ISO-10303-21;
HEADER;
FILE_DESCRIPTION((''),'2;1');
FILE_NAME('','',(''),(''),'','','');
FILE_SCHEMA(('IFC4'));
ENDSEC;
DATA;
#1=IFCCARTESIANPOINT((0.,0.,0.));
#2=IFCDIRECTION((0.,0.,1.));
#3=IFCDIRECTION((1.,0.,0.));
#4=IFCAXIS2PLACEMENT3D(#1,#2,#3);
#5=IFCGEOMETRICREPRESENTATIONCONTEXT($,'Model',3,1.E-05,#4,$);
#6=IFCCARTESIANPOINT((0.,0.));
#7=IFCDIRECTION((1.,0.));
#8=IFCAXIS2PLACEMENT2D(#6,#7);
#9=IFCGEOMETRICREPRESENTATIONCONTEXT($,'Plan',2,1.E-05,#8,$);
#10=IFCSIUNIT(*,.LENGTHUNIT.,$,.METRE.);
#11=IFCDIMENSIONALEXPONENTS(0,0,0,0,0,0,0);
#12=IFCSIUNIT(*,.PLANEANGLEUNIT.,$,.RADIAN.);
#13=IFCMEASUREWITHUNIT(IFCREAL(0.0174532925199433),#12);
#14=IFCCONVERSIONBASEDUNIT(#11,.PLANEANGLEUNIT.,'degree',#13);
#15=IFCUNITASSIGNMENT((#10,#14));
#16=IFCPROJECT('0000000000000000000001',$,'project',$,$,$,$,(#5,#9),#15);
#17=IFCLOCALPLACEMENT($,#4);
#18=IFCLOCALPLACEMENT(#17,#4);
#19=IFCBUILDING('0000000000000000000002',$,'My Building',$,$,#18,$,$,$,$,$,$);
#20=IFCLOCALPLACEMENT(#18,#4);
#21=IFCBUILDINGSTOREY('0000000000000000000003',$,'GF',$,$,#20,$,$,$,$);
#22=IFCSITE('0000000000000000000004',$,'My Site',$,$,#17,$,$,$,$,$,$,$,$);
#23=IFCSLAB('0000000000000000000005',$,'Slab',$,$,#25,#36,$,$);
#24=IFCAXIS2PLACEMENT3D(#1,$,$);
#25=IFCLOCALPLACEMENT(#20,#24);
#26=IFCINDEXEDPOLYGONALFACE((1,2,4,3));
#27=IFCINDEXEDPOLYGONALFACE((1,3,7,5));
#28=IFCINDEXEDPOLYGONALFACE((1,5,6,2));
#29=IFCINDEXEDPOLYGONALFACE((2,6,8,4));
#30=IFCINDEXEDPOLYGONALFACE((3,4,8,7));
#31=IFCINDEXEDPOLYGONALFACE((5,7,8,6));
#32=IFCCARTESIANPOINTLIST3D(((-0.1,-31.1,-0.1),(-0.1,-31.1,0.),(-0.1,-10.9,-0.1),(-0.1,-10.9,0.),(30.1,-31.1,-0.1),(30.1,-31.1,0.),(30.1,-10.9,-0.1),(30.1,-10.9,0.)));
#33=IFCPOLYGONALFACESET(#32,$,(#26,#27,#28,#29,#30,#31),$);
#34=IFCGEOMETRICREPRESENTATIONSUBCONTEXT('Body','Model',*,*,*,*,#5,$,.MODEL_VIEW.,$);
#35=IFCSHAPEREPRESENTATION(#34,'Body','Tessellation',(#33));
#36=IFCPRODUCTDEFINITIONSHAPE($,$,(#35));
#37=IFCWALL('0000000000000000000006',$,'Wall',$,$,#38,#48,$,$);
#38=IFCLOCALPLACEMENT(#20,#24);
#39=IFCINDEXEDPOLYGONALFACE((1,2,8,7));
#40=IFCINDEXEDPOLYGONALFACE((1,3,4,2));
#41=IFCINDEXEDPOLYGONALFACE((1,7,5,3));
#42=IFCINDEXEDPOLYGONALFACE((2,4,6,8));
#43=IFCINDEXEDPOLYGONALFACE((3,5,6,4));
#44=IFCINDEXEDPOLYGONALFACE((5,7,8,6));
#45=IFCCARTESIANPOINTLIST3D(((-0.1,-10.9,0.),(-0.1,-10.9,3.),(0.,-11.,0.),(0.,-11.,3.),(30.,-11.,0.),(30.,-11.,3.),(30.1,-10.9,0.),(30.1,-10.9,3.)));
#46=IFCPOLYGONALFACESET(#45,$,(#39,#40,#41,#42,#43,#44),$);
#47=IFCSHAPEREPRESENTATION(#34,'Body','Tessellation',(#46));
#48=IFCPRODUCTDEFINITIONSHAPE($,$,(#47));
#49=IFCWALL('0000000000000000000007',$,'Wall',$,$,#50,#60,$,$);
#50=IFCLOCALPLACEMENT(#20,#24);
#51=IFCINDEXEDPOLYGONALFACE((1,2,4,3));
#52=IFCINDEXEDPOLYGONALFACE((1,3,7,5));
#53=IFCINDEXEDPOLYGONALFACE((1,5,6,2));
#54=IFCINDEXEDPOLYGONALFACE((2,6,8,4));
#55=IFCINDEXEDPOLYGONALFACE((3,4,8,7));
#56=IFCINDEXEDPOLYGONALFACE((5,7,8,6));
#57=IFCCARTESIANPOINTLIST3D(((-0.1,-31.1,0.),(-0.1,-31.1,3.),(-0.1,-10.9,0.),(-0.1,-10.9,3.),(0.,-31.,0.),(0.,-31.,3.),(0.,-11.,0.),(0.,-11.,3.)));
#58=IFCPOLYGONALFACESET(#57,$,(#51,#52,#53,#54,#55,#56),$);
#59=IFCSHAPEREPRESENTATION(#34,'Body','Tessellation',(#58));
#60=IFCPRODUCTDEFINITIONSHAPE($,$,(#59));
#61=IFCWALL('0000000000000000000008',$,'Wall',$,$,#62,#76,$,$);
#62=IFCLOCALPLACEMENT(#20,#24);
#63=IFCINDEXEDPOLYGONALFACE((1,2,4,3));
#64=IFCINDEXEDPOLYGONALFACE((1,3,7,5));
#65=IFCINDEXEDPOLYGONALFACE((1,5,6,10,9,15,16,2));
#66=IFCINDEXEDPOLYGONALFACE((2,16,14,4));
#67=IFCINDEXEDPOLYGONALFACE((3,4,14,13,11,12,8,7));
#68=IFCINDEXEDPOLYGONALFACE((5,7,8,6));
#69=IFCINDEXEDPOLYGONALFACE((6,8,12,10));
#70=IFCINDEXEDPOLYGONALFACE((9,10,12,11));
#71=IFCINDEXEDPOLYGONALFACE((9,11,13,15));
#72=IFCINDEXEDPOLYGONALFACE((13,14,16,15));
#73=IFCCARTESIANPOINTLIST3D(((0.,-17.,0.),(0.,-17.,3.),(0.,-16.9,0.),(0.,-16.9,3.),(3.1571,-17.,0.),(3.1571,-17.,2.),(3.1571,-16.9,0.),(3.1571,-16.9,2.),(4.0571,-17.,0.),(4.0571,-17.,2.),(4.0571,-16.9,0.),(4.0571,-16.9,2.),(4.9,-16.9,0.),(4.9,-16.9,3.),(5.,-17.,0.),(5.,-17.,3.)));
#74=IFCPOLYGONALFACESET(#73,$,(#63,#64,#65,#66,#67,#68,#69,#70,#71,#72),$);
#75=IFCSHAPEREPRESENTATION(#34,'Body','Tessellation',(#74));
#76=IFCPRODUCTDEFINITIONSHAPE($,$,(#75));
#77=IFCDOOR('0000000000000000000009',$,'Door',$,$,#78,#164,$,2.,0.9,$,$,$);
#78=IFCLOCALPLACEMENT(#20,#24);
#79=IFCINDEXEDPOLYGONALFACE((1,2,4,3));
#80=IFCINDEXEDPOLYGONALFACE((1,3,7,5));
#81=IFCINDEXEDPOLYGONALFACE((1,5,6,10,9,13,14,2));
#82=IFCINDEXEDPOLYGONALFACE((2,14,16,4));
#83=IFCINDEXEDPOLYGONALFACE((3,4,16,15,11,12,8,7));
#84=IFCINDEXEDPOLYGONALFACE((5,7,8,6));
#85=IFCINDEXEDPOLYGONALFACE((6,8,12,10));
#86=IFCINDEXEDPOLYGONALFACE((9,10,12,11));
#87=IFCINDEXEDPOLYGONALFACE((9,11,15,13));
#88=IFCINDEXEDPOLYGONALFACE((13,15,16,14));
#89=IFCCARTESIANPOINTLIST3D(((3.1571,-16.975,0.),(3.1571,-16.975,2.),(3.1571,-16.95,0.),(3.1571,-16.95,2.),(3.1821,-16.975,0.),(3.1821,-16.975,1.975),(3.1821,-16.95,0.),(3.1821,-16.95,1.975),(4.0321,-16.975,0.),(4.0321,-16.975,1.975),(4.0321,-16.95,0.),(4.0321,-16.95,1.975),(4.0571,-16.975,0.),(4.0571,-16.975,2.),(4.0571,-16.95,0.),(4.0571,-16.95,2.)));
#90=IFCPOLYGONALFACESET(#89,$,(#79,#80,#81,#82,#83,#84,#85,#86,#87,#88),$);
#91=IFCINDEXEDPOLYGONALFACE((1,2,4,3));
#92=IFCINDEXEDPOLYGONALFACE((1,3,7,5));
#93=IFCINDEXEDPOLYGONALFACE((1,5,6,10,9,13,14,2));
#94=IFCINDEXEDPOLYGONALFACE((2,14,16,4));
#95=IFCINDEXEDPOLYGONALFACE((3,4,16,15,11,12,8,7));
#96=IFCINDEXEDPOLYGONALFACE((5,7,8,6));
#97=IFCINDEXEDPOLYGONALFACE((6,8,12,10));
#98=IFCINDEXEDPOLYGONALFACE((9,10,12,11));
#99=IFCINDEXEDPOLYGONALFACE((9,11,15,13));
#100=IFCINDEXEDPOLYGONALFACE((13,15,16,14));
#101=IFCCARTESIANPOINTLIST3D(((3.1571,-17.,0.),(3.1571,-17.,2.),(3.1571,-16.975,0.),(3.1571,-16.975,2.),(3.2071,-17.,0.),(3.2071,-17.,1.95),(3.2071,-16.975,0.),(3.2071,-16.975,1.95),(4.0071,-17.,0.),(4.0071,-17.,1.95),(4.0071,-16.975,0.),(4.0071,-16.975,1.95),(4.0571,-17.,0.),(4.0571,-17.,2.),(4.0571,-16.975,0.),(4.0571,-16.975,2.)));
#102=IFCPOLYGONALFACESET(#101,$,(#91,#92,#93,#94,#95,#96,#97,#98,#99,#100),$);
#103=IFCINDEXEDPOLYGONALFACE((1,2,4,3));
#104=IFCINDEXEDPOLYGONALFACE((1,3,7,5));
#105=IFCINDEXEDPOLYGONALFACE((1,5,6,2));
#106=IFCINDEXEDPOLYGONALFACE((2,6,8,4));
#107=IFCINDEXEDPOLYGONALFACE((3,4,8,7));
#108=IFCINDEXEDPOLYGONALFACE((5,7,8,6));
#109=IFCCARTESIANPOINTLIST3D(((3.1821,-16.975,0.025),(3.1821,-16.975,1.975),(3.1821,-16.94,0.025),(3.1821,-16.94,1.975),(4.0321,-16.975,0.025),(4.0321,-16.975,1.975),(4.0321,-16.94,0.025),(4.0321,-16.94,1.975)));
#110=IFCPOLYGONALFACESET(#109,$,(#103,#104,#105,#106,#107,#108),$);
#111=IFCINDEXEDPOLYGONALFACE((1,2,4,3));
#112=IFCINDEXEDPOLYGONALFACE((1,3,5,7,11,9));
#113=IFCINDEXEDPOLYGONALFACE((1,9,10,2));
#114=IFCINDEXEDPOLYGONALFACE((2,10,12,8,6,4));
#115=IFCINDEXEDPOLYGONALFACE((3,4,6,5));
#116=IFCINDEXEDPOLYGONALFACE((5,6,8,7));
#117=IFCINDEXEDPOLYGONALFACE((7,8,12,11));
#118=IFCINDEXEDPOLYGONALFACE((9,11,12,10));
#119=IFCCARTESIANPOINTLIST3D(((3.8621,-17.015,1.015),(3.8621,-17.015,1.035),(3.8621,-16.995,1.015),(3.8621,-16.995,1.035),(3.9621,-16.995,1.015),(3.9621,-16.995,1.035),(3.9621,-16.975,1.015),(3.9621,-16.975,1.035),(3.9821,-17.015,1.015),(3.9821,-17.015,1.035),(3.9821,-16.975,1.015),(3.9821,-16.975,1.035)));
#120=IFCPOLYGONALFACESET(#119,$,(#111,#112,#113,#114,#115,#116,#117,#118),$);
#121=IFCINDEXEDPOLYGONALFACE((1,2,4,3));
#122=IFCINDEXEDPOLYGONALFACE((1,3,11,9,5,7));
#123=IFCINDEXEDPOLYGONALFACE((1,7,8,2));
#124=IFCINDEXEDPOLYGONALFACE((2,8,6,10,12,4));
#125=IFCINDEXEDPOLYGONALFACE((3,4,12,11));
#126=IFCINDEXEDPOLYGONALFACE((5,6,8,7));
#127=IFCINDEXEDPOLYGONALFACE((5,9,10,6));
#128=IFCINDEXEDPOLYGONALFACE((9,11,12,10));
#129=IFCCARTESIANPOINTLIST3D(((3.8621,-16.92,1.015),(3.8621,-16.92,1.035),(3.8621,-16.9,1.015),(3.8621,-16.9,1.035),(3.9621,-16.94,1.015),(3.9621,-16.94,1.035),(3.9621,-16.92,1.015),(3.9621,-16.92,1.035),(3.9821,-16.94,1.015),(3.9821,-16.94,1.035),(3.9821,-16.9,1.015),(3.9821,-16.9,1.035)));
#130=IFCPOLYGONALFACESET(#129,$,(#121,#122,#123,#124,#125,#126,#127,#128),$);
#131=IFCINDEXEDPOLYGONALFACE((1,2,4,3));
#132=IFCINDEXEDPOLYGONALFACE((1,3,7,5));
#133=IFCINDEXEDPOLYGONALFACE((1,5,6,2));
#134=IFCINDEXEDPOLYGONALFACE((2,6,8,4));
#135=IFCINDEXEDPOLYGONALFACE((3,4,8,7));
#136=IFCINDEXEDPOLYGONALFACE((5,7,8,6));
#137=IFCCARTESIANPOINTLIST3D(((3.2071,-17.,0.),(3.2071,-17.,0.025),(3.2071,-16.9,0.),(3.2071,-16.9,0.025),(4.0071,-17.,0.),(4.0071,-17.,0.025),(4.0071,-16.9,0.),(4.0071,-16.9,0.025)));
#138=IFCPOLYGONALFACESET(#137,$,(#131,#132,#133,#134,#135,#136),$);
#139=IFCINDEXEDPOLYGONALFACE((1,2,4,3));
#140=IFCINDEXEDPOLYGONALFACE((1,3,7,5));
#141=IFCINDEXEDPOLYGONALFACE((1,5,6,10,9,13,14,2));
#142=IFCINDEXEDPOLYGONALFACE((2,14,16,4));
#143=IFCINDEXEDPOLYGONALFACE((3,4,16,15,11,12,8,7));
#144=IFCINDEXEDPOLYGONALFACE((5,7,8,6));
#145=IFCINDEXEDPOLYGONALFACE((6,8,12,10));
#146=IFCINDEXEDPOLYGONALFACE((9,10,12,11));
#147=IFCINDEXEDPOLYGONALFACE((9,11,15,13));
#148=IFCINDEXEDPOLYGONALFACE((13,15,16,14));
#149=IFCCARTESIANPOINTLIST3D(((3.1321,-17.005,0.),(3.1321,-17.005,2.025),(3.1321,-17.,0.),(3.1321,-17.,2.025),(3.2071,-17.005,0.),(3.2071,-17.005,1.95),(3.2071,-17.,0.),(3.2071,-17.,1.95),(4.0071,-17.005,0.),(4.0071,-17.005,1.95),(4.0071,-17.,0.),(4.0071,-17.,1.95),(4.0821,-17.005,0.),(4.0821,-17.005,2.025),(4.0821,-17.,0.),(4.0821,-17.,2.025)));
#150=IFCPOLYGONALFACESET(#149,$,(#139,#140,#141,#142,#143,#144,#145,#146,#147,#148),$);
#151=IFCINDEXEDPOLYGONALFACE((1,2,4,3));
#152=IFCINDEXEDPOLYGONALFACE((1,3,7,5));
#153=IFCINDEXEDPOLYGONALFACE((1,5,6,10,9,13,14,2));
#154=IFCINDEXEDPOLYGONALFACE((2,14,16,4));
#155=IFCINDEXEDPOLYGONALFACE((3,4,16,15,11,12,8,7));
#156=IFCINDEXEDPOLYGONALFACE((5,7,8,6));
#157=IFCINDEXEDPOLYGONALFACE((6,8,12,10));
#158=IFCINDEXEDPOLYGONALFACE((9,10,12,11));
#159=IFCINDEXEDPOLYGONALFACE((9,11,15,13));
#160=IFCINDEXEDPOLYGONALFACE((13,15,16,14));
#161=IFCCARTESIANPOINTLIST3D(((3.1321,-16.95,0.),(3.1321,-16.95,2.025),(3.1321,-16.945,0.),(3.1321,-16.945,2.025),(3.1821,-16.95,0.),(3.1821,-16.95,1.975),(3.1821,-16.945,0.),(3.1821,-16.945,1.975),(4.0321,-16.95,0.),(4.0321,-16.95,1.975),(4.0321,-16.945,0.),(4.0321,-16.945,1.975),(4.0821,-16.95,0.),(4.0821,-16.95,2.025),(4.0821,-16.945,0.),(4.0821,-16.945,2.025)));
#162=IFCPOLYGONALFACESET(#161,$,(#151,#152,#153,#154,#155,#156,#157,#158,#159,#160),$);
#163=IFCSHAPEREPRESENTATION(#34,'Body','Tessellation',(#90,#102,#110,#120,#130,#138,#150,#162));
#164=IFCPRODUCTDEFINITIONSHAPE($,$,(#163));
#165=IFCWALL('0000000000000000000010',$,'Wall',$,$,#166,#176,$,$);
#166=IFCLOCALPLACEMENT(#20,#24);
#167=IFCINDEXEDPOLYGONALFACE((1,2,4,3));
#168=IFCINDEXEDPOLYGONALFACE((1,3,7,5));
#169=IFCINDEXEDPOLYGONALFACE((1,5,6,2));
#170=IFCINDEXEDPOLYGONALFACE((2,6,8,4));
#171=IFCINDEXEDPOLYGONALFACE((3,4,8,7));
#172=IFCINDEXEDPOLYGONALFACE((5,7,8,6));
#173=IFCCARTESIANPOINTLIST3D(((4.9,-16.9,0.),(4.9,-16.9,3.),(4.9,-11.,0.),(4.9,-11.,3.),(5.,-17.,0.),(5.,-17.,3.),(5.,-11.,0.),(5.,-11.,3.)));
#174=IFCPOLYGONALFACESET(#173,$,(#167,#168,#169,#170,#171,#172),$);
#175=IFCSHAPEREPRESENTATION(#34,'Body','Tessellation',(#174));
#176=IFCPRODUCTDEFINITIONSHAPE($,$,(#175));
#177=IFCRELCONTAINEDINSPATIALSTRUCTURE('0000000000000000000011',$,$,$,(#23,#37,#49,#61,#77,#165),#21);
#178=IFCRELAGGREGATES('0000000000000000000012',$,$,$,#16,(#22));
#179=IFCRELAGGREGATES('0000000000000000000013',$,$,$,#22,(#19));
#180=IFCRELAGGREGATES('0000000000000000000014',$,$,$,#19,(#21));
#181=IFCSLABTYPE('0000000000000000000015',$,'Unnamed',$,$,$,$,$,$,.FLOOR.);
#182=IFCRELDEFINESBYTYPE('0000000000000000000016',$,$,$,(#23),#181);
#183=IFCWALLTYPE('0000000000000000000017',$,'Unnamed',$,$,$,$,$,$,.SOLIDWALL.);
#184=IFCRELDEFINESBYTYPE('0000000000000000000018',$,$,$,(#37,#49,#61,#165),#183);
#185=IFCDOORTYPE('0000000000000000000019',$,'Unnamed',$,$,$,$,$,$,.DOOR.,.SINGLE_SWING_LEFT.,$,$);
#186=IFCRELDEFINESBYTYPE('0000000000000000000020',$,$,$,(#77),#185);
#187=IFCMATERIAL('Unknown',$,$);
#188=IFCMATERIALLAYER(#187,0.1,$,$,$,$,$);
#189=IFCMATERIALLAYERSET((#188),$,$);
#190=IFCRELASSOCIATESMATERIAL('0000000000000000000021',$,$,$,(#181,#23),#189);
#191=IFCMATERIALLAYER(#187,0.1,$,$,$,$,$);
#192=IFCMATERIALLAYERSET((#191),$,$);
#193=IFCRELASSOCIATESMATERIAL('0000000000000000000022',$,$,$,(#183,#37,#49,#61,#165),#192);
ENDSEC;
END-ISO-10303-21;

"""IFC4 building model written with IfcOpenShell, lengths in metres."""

from ifc_helpers import new_model, entity, si_unit, converted_unit, frame, origin_with_axes, origin_2d_with_axis, place, context, subcontext, project, spatial, line, indexed_curve, outline, extrude, shape, source, transform, mapped, material, layer, layer_set, layer_usage, type_object, type_shapes, element, fill, save


model = new_model("IFC4")

# Units and contexts
model_context = context("Model", 3, precision=1e-05, world=origin_with_axes())
plan_context = context("Plan", 2, precision=1e-05, world=origin_2d_with_axis())
body_context_1 = subcontext(model_context, "Body", "Model", "MODEL_VIEW")
body_context_2 = subcontext(plan_context, "Body", "Plan", "PLAN_VIEW")
ifc_project = project(units=[si_unit("LENGTHUNIT", "METRE"), converted_unit("PLANEANGLEUNIT", "degree", entity("IfcReal", 0.0174532925199433), si_unit("PLANEANGLEUNIT", "RADIAN"), dimensions=[0, 0, 0, 0, 0, 0, 0])], contexts=[model_context, plan_context])

# Site, building, storey
site_placement = place(None, origin_with_axes())
site = spatial("IfcSite", under=ifc_project, at=site_placement, Name="My Site")
building_placement = place(site_placement, origin_with_axes())
building = spatial("IfcBuilding", under=site, at=building_placement, Name="My Building")
storey_placement = place(building_placement, origin_with_axes())
storey = spatial("IfcBuildingStorey", under=building, at=storey_placement, Name="GF")

# Slab
ifc_material = material(Name="Unknown")
ifc_layer_1 = layer(ifc_material, 0.1)
ifc_layer_set_1 = layer_set([ifc_layer_1])
ifc_layer_usage_1 = layer_usage(ifc_layer_set_1, "AXIS3", "POSITIVE", -0.1)
slab_type = type_object("IfcSlabType", Name="Unnamed", PredefinedType="FLOOR", material=ifc_layer_set_1)
slab_placement = place(storey_placement, frame((-0.1, -10.9, 0.0), z_axis=(0.0, 0.0, 1.0), x_axis=(1.0, 0.0, 0.0)))
element("IfcSlab", 1, at=slab_placement, inside=storey, type_object=slab_type, material=ifc_layer_usage_1, Name="Slab", context=body_context_1, shape_type="SweptSolid", body=[
    extrude(outline(indexed_curve([(0.0, 0.0), (30.2, 0.0), (30.2, -20.2), (0.0, -20.2), (0.0, 0.0)])), frame((0.0, 0.0, -0.1), z_axis=(0.0, 0.0, 1.0), x_axis=(1.0, 0.0, 0.0)), (0.0, 0.0, 1.0), 0.1),
])

# Walls
ifc_layer_2 = layer(ifc_material, 0.1)
ifc_layer_set_2 = layer_set([ifc_layer_2])
ifc_layer_usage_2 = layer_usage(ifc_layer_set_2, "AXIS2", "POSITIVE", 0.0)
wall_type = type_object("IfcWallType", Name="Unnamed", PredefinedType="SOLIDWALL", material=ifc_layer_set_2)
wall_1_placement = place(storey_placement, frame((0.0, -11.0, 0.0), z_axis=(0.0, 0.0, 1.0), x_axis=(1.0, 0.0, 0.0)))
element("IfcWall", 2, at=wall_1_placement, inside=storey, type_object=wall_type, material=ifc_layer_usage_2, Name="Wall", context=body_context_1, shape_type="SweptSolid", body=[
    extrude(outline(indexed_curve([(0.0, 0.0), (-0.1, 0.1), (30.1, 0.1), (30.0, 0.0)], segments=[line(1, 2, 3, 4, 1)])), origin_with_axes(), (0.0, 0.0, 1.0), 3.0),
])
ifc_layer_usage_3 = layer_usage(ifc_layer_set_2, "AXIS2", "POSITIVE", 0.0)
wall_2_placement = place(storey_placement, frame((0.0, -31.0, 0.0), z_axis=(0.0, 0.0, 1.0), x_axis=(0.0, 1.0, 0.0)))
element("IfcWall", 3, at=wall_2_placement, inside=storey, type_object=wall_type, material=ifc_layer_usage_3, Name="Wall", context=body_context_1, shape_type="SweptSolid", body=[
    extrude(outline(indexed_curve([(0.0, 0.0), (-0.1, 0.1), (20.1, 0.1), (20.0, 0.0)], segments=[line(1, 2, 3, 4, 1)])), origin_with_axes(), (0.0, 0.0, 1.0), 3.0),
])

# Wall, opening, door
ifc_layer_usage_4 = layer_usage(ifc_layer_set_2, "AXIS2", "POSITIVE", 0.0)
wall_3_placement = place(storey_placement, frame((0.0, -17.0, 0.0), z_axis=(0.0, 0.0, 1.0), x_axis=(1.0, 0.0, 0.0)))
wall_3 = element("IfcWall", 4, at=wall_3_placement, inside=storey, type_object=wall_type, material=ifc_layer_usage_4, Name="Wall", context=body_context_1, shape_type="SweptSolid", body=[
    extrude(outline(indexed_curve([(0.0, 0.0), (0.0, 0.1), (4.9, 0.1), (5.0, 0.0)], segments=[line(1, 2, 3, 4, 1)])), origin_with_axes(), (0.0, 0.0, 1.0), 3.0),
])
shared_shape_1 = source(origin_with_axes(), body_context_1, "Body", "SweptSolid", [
    extrude(outline(indexed_curve([(0.0, 0.0), (0.9, 0.0), (0.9, 2.0), (0.0, 2.0)], segments=[line(1, 2, 3, 4, 1)])), frame((0.0, -0.6, 0.0), z_axis=(0.0, -1.0, 0.0), x_axis=(1.0, 0.0, 0.0)), (0.0, 0.0, -1.0), 1.2),
])
opening_1_placement = place(wall_3_placement, frame((3.1571, 0.0, 0.0), z_axis=(0.0, 0.0, 1.0), x_axis=(1.0, 0.0, 0.0)))
opening_1 = element("IfcOpeningElement", 5, at=opening_1_placement, cuts=wall_3, PredefinedType="OPENING", context=body_context_1, shape_type="MappedRepresentation", body=[
    mapped(shared_shape_1, transform((0.0, 0.0, 0.0), x_axis=(1.0, 0.0, 0.0), y_axis=(0.0, 1.0, 0.0), z_axis=(0.0, 0.0, 1.0), scale=1.0)),
])
door_type = type_object("IfcDoorType", Name="Unnamed", OperationType="SINGLE_SWING_LEFT", PredefinedType="DOOR")
shared_shape_2 = source(origin_with_axes(), body_context_1, "Body", "SweptSolid", [
    extrude(outline(indexed_curve([(0.0, 0.0), (0.0, 2.0), (0.9, 2.0), (0.9, 0.0), (0.875, 0.0), (0.875, 1.975), (0.025, 1.975), (0.025, 0.0)], segments=[line(1, 2, 3, 4, 5, 6, 7, 8, 1)])), frame((0.0, 0.025, 0.0), z_axis=(0.0, -1.0, 0.0), x_axis=(1.0, 0.0, 0.0)), (0.0, 0.0, -1.0), 0.025),
    extrude(outline(indexed_curve([(0.0, 0.0), (0.0, 2.0), (0.9, 2.0), (0.9, 0.0), (0.85, 0.0), (0.85, 1.95), (0.05, 1.95), (0.05, 0.0)], segments=[line(1, 2, 3, 4, 5, 6, 7, 8, 1)])), frame((0.0, 0.0, 0.0), z_axis=(0.0, -1.0, 0.0), x_axis=(1.0, 0.0, 0.0)), (0.0, 0.0, -1.0), 0.025),
    extrude(outline(indexed_curve([(0.0, 0.0), (0.85, 0.0), (0.85, 0.035), (0.0, 0.035)], segments=[line(1, 2, 3, 4, 1)])), frame((0.025, 0.025, 0.025), z_axis=(0.0, 0.0, 1.0), x_axis=(1.0, 0.0, 0.0)), (0.0, 0.0, 1.0), 1.95),
    extrude(outline(indexed_curve([(0.0, 0.0), (0.0, -0.04), (-0.12, -0.04), (-0.12, -0.02), (-0.02, -0.02), (-0.02, 0.0)], segments=[line(1, 2, 3, 4, 5, 6, 1)])), frame((0.825, 0.025, 1.015), z_axis=(0.0, 0.0, 1.0), x_axis=(1.0, 0.0, 0.0)), (0.0, 0.0, 1.0), 0.02),
    extrude(outline(indexed_curve([(0.0, 0.0), (0.0, 0.04), (-0.12, 0.04), (-0.12, 0.02), (-0.02, 0.02), (-0.02, 0.0)], segments=[line(1, 2, 3, 4, 5, 6, 1)])), frame((0.825, 0.06, 1.015), z_axis=(0.0, 0.0, 1.0), x_axis=(1.0, 0.0, 0.0)), (0.0, 0.0, 1.0), 0.02),
    extrude(outline(indexed_curve([(0.0, 0.0), (0.8, 0.0), (0.8, 0.1), (0.0, 0.1)], segments=[line(1, 2, 3, 4, 1)])), frame((0.05, 0.0, 0.0), z_axis=(0.0, 0.0, 1.0), x_axis=(1.0, 0.0, 0.0)), (0.0, 0.0, 1.0), 0.025),
    extrude(outline(indexed_curve([(0.0, 0.0), (0.0, 2.025), (0.95, 2.025), (0.95, 0.0), (0.875, 0.0), (0.875, 1.95), (0.075, 1.95), (0.075, 0.0)], segments=[line(1, 2, 3, 4, 5, 6, 7, 8, 1)])), frame((-0.025, -0.005, 0.0), z_axis=(0.0, -1.0, 0.0), x_axis=(1.0, 0.0, 0.0)), (0.0, 0.0, -1.0), 0.005),
    extrude(outline(indexed_curve([(0.0, 0.0), (0.0, 2.025), (0.95, 2.025), (0.95, 0.0), (0.9, 0.0), (0.9, 1.975), (0.05, 1.975), (0.05, 0.0)], segments=[line(1, 2, 3, 4, 5, 6, 7, 8, 1)])), frame((-0.025, 0.05, 0.0), z_axis=(0.0, -1.0, 0.0), x_axis=(1.0, 0.0, 0.0)), (0.0, 0.0, -1.0), 0.005),
])
shared_shape_3 = source(origin_with_axes(), body_context_2, "Body", "Curve2D", [
    entity("IfcIndexedPolyCurve", entity("IfcCartesianPointList2D", [[0.0, 0.0], [0.0, 0.05], [0.025, 0.05], [0.025, 0.025], [0.05, 0.025], [0.05, 0.0]]), [entity("IfcLineIndex", [1, 2, 3, 4, 5, 6, 1])]),
    entity("IfcIndexedPolyCurve", entity("IfcCartesianPointList2D", [[0.9, 0.0], [0.9, 0.05], [0.875, 0.05], [0.875, 0.025], [0.85, 0.025], [0.85, 0.0]]), [entity("IfcLineIndex", [1, 2, 3, 4, 5, 6, 1])]),
    entity("IfcTrimmedCurve", entity("IfcEllipse", entity("IfcAxis2Placement2D", entity("IfcCartesianPoint", [0.06, 0.05]), entity("IfcDirection", [1.0, 0.0])), 0.815, 0.85), [entity("IfcCartesianPoint", [0.875, 0.05])], [entity("IfcCartesianPoint", [0.06, 0.9])], True, "CARTESIAN"),
    entity("IfcIndexedPolyCurve", entity("IfcCartesianPointList2D", [[0.025, 0.05], [0.06, 0.05], [0.06, 0.9], [0.025, 0.9]]), [entity("IfcLineIndex", [1, 2, 3, 4, 1])]),
])
type_shapes(door_type, [shared_shape_2, shared_shape_3])
door_1_placement = place(opening_1_placement, origin_with_axes())
door_1 = element("IfcDoor", 6, at=door_1_placement, inside=storey, type_object=door_type, Name="Door", OverallHeight=2.0, OverallWidth=0.9, shapes=[
    shape(body_context_1, "Body", "MappedRepresentation", [mapped(shared_shape_2, transform((0.0, 0.0, 0.0), x_axis=(1.0, 0.0, 0.0), y_axis=(0.0, 1.0, 0.0), z_axis=(0.0, 0.0, 1.0), scale=1.0))]),
    shape(body_context_2, "Body", "MappedRepresentation", [mapped(shared_shape_3, transform((0.0, 0.0, 0.0), x_axis=(1.0, 0.0, 0.0), y_axis=(0.0, 1.0, 0.0), z_axis=(0.0, 0.0, 1.0), scale=1.0))]),
])
fill(opening_1, door_1)

# Wall
ifc_layer_usage_5 = layer_usage(ifc_layer_set_2, "AXIS2", "POSITIVE", 0.0)
wall_4_placement = place(storey_placement, frame((5.0, -17.0, 0.0), z_axis=(0.0, 0.0, 1.0), x_axis=(0.0, 1.0, 0.0)))
element("IfcWall", 7, at=wall_4_placement, inside=storey, type_object=wall_type, material=ifc_layer_usage_5, Name="Wall", context=body_context_1, shape_type="SweptSolid", body=[
    extrude(outline(indexed_curve([(0.0, 0.0), (0.1, 0.1), (6.0, 0.1), (6.0, 0.0)], segments=[line(1, 2, 3, 4, 1)])), origin_with_axes(), (0.0, 0.0, 1.0), 3.0),
])

save(model, "model.ifc")
